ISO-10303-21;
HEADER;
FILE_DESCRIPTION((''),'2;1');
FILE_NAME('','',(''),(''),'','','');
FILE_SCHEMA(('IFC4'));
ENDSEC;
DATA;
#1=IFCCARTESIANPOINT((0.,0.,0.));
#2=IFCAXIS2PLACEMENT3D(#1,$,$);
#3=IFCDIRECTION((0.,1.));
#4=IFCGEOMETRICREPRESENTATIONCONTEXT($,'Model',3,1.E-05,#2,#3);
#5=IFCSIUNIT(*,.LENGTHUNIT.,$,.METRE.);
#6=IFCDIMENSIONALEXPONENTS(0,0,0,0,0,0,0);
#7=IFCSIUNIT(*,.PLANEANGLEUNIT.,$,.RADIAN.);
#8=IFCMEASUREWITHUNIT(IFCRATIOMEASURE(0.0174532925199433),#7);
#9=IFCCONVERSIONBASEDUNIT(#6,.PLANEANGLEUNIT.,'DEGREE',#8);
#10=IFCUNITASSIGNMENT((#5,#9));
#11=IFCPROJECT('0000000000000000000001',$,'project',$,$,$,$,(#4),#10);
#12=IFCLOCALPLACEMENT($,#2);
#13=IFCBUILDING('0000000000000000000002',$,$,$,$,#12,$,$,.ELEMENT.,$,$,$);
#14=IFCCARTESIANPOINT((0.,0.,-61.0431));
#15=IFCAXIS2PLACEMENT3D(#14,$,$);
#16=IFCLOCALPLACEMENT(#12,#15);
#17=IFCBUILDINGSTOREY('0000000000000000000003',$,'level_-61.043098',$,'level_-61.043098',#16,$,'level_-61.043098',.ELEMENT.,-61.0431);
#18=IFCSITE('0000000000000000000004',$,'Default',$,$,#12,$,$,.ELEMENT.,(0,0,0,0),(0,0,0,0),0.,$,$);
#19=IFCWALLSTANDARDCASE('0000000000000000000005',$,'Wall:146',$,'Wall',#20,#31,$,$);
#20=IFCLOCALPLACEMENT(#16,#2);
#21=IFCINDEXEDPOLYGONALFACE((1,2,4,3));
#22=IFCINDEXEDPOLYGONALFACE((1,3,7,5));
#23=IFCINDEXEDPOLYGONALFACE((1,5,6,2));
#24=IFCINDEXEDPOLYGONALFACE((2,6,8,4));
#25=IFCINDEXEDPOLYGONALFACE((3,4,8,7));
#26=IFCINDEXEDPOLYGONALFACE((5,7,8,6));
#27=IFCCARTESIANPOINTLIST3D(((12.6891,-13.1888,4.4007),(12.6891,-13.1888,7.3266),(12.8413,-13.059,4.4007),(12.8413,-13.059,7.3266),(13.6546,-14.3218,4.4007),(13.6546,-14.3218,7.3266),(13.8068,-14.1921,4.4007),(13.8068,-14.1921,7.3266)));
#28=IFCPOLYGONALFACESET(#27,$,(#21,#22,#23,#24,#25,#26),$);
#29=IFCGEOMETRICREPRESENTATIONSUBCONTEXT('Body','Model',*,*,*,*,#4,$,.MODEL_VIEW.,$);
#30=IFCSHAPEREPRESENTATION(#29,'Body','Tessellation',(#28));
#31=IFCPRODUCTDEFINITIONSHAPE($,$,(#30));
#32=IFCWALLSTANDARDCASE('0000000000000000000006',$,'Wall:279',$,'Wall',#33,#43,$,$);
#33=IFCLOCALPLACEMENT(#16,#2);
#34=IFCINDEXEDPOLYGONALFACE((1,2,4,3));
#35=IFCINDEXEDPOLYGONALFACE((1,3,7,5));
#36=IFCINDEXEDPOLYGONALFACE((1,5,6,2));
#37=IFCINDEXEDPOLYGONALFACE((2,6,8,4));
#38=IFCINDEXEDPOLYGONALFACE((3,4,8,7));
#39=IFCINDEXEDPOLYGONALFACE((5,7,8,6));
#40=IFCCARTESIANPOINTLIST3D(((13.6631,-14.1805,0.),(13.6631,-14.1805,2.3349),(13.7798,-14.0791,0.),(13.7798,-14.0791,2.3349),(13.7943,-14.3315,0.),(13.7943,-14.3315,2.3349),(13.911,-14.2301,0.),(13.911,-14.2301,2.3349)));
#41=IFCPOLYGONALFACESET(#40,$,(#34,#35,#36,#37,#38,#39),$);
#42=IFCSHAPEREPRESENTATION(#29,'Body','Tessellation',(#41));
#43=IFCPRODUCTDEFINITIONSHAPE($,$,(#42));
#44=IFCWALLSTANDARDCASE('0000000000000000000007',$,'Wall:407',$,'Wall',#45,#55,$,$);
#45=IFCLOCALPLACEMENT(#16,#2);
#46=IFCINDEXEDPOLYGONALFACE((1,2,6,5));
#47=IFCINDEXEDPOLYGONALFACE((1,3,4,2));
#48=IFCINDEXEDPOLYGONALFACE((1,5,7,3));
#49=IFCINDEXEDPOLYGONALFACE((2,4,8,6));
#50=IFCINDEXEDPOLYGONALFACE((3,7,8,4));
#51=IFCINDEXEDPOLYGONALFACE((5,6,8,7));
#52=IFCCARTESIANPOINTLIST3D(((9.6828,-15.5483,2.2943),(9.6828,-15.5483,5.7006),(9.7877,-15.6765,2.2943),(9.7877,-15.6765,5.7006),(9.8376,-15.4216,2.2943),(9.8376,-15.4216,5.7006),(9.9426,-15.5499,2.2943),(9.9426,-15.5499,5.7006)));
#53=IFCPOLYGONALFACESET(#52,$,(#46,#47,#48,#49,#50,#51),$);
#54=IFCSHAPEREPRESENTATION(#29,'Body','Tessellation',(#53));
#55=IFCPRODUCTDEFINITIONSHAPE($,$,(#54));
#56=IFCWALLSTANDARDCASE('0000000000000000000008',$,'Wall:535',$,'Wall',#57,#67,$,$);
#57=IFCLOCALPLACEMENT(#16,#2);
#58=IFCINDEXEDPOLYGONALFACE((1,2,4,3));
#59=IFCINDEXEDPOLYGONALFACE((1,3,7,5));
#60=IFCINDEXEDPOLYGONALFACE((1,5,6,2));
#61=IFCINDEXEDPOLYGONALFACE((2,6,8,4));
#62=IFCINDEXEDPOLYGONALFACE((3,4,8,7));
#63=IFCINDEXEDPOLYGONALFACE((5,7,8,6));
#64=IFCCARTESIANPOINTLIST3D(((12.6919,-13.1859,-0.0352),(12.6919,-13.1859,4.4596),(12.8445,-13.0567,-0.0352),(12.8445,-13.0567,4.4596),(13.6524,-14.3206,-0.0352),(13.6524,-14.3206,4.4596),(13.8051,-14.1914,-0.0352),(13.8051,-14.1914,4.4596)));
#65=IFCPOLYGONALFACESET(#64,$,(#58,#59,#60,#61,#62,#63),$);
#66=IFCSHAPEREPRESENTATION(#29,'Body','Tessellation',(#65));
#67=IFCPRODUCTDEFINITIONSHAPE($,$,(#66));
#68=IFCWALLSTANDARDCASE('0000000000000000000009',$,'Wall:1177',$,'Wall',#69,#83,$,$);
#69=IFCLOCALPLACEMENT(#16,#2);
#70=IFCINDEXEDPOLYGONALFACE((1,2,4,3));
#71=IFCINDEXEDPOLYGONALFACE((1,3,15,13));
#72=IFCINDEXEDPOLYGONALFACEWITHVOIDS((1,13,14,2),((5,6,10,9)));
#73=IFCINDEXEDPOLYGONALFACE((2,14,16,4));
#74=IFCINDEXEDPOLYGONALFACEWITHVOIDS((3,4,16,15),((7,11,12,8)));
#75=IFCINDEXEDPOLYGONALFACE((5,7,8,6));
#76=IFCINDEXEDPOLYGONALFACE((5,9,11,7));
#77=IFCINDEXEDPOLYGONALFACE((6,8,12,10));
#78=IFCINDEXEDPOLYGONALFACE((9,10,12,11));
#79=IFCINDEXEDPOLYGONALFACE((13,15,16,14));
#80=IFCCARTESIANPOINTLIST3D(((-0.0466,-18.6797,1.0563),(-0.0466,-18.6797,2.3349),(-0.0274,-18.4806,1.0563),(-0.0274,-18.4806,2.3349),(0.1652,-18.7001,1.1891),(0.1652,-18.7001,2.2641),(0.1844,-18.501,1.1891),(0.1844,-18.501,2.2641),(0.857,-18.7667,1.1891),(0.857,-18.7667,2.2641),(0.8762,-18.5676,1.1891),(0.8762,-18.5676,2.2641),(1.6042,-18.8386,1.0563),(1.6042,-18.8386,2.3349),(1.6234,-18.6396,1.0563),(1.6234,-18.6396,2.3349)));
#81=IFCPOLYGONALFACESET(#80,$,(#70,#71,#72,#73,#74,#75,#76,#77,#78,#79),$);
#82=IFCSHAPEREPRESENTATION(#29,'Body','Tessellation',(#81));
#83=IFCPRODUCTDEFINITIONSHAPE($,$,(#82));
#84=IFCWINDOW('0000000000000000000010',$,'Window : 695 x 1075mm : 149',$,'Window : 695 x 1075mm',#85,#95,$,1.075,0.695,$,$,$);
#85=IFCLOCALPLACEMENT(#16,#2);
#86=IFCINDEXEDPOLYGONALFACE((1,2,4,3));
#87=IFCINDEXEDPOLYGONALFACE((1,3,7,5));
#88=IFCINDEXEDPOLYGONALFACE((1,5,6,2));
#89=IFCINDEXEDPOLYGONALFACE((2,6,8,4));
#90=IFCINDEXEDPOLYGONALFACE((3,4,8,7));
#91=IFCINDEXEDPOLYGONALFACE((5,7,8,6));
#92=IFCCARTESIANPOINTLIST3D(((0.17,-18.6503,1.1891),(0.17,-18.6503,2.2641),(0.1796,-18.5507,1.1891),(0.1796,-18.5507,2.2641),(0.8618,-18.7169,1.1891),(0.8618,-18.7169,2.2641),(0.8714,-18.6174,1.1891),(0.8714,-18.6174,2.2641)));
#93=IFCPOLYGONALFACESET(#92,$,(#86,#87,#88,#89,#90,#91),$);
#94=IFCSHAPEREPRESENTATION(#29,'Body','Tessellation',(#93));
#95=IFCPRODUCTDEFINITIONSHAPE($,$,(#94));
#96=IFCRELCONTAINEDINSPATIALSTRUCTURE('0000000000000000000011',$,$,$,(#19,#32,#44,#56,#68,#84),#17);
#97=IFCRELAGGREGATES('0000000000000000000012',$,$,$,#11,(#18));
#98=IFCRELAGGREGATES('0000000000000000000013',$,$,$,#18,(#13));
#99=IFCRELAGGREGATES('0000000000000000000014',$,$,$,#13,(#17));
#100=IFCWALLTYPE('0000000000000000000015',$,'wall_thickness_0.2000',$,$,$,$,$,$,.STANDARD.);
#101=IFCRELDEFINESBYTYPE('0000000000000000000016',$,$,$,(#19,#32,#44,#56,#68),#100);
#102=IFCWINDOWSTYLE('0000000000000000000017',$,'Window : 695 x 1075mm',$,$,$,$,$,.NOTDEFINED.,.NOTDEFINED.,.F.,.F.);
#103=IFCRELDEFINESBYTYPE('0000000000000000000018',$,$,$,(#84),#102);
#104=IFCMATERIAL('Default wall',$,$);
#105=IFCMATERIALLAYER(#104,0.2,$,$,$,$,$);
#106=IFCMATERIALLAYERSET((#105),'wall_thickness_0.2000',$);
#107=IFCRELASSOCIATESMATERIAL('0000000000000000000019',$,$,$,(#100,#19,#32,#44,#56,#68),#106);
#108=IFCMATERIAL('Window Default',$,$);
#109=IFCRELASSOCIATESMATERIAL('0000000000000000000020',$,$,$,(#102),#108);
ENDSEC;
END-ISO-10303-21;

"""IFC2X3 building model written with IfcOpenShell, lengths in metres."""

from ifc_helpers import new_model, entity, si_unit, converted_unit, direction, frame, frame_2d, origin, origin_2d_with_axis, place, context, subcontext, project, spatial, polyline, rectangle, outline, extrude, source, transform, mapped, material, layer, layer_set, layer_usage, type_object, type_shapes, element, fill, save


model = new_model("IFC2X3")

# Units and contexts
model_context = context("Model", 3, precision=1e-05, world=origin(), true_north=direction((0.0, 1.0)))
body_context = subcontext(model_context, "Body", "Model", "MODEL_VIEW")
ifc_project = project(units=[si_unit("LENGTHUNIT", "METRE"), converted_unit("PLANEANGLEUNIT", "DEGREE", entity("IfcRatioMeasure", 0.0174532925199433), si_unit("PLANEANGLEUNIT", "RADIAN"), dimensions=[0, 0, 0, 0, 0, 0, 0])], contexts=[model_context])

# Site, building, storey
placement_1 = place(None, origin())
site = spatial("IfcSite", under=ifc_project, at=placement_1, Name="Default", CompositionType="ELEMENT", RefLatitude=(0, 0, 0, 0), RefLongitude=(0, 0, 0, 0), RefElevation=0.0)
building = spatial("IfcBuilding", under=site, at=placement_1, CompositionType="ELEMENT")
storey_placement = place(placement_1, frame((0.0, 0.0, -61.0431)))
storey = spatial("IfcBuildingStorey", under=building, at=storey_placement, Name="level_-61.043098", ObjectType="level_-61.043098", LongName="level_-61.043098", CompositionType="ELEMENT", Elevation=-61.0431)

# Walls
ifc_material_1 = material(Name="Default wall")
ifc_layer = layer(ifc_material_1, 0.2)
ifc_layer_set = layer_set([ifc_layer], Name="wall_thickness_0.2000")
ifc_layer_usage = layer_usage(ifc_layer_set, "AXIS2", "POSITIVE", -0.1)
wall_type = type_object("IfcWallType", Name="wall_thickness_0.2000", PredefinedType="STANDARD", material=ifc_layer_set)
placement_2 = place(placement_1, frame((0.0, 0.0, -56.6424)))
wall_1_placement = place(placement_2, frame((13.7307, -14.257, 0.0), z_axis=(0.0, 0.0, 1.0), x_axis=(-0.648596, 0.761133, 0.0)))
element("IfcWallStandardCase", 1, at=wall_1_placement, inside=storey, type_object=wall_type, material=ifc_layer_usage, Name="Wall:146", ObjectType="Wall", context=body_context, shape_type="SweptSolid", body=[
    extrude(outline(polyline([(1.4887, -0.1), (1.4887, 0.1), (0.0, 0.1), (0.0, -0.1), (1.4887, -0.1)])), origin(), (0.0, 0.0, 1.0), 2.9259),
])
wall_2_placement = place(storey_placement, frame((13.8454, -14.1546, 0.0), z_axis=(0.0, 0.0, 1.0), x_axis=(-0.754916, -0.655821, 0.0)))
element("IfcWallStandardCase", 2, at=wall_2_placement, inside=storey, type_object=wall_type, material=ifc_layer_usage, Name="Wall:279", ObjectType="Wall", context=body_context, shape_type="SweptSolid", body=[
    extrude(outline(polyline([(0.1545, -0.1), (0.1545, 0.1), (0.0, 0.1), (0.0, -0.1), (0.1545, -0.1)])), origin(), (0.0, 0.0, 1.0), 2.3349),
])
placement_3 = place(placement_1, frame((0.0, 0.0, -58.7488)))
wall_3_placement = place(placement_3, frame((9.8651, -15.6132, 0.0), z_axis=(0.0, 0.0, 1.0), x_axis=(-0.633091, 0.774078, 0.0)))
element("IfcWallStandardCase", 3, at=wall_3_placement, inside=storey, type_object=wall_type, material=ifc_layer_usage, Name="Wall:407", ObjectType="Wall", context=body_context, shape_type="SweptSolid", body=[
    extrude(outline(polyline([(0.1657, -0.1), (0.1657, 0.1), (0.0, 0.1), (0.0, -0.1), (0.1657, -0.1)])), origin(), (0.0, 0.0, 1.0), 3.4063),
])
placement_4 = place(placement_1, frame((0.0, 0.0, -61.0783)))
wall_4_placement = place(placement_4, frame((13.7287, -14.256, 0.0), z_axis=(0.0, 0.0, 1.0), x_axis=(-0.646113, 0.763242, 0.0)))
element("IfcWallStandardCase", 4, at=wall_4_placement, inside=storey, type_object=wall_type, material=ifc_layer_usage, Name="Wall:535", ObjectType="Wall", context=body_context, shape_type="SweptSolid", body=[
    extrude(outline(polyline([(1.4866, -0.1), (1.4866, 0.1), (0.0, 0.1), (0.0, -0.1), (1.4866, -0.1)])), origin(), (0.0, 0.0, 1.0), 4.4948),
])

# Wall, opening, window
placement_5 = place(placement_1, frame((0.0, 0.0, -59.9868)))
wall_5_placement = place(placement_5, frame((1.6138, -18.7391, 0.0), z_axis=(0.0, 0.0, 1.0), x_axis=(-0.995394, 0.095869, 0.0)))
wall_5 = element("IfcWallStandardCase", 5, at=wall_5_placement, inside=storey, type_object=wall_type, material=ifc_layer_usage, Name="Wall:1177", ObjectType="Wall", context=body_context, shape_type="SweptSolid", body=[
    extrude(outline(polyline([(1.6584, -0.1), (1.6584, 0.1), (0.0, 0.1), (0.0, -0.1), (1.6584, -0.1)])), origin(), (0.0, 0.0, 1.0), 1.2785),
])
opening_1_placement = place(wall_5_placement, frame((0.7506, -0.1, 0.1328)))
opening_1 = element("IfcOpeningElement", 6, at=opening_1_placement, cuts=wall_5, ObjectType="Opening", context=body_context, shape_type="SweptSolid", body=[
    extrude(rectangle(XDim=0.695, YDim=1.075, at=frame_2d((0.5375, 0.3475), x_axis=(0.0, 1.0))), frame((0.0, 0.0, 0.0), z_axis=(0.0, 1.0, 0.0), x_axis=(0.0, 0.0, 1.0)), (0.0, 0.0, 1.0), 0.2),
])
ifc_material_2 = material(Name="Window Default")
window_style_1 = type_object("IfcWindowStyle", Name="Window : 695 x 1075mm", ConstructionType="NOTDEFINED", OperationType="NOTDEFINED", ParameterTakesPrecedence=False, Sizeable=False, material=ifc_material_2)
shared_shape_1 = source(origin(), body_context, "Body", "SweptSolid", [
    extrude(rectangle(XDim=0.1, YDim=0.695, at=origin_2d_with_axis()), frame((0.3475, 0.1, 0.0), z_axis=(0.0, 0.0, 1.0), x_axis=(0.0, 1.0, 0.0)), (0.0, 0.0, 1.0), 1.075),
])
type_shapes(window_style_1, [shared_shape_1])
window_1_placement = place(opening_1_placement, origin())
window_1 = element("IfcWindow", 7, at=window_1_placement, inside=storey, type_object=window_style_1, Name="Window : 695 x 1075mm : 149", ObjectType="Window : 695 x 1075mm", OverallHeight=1.075, OverallWidth=0.695, context=body_context, shape_type="MappedRepresentation", body=[
    mapped(shared_shape_1, transform((0.0, 0.0, 0.0), scale=1.0)),
])
fill(opening_1, window_1)

save(model, "model.ifc")
